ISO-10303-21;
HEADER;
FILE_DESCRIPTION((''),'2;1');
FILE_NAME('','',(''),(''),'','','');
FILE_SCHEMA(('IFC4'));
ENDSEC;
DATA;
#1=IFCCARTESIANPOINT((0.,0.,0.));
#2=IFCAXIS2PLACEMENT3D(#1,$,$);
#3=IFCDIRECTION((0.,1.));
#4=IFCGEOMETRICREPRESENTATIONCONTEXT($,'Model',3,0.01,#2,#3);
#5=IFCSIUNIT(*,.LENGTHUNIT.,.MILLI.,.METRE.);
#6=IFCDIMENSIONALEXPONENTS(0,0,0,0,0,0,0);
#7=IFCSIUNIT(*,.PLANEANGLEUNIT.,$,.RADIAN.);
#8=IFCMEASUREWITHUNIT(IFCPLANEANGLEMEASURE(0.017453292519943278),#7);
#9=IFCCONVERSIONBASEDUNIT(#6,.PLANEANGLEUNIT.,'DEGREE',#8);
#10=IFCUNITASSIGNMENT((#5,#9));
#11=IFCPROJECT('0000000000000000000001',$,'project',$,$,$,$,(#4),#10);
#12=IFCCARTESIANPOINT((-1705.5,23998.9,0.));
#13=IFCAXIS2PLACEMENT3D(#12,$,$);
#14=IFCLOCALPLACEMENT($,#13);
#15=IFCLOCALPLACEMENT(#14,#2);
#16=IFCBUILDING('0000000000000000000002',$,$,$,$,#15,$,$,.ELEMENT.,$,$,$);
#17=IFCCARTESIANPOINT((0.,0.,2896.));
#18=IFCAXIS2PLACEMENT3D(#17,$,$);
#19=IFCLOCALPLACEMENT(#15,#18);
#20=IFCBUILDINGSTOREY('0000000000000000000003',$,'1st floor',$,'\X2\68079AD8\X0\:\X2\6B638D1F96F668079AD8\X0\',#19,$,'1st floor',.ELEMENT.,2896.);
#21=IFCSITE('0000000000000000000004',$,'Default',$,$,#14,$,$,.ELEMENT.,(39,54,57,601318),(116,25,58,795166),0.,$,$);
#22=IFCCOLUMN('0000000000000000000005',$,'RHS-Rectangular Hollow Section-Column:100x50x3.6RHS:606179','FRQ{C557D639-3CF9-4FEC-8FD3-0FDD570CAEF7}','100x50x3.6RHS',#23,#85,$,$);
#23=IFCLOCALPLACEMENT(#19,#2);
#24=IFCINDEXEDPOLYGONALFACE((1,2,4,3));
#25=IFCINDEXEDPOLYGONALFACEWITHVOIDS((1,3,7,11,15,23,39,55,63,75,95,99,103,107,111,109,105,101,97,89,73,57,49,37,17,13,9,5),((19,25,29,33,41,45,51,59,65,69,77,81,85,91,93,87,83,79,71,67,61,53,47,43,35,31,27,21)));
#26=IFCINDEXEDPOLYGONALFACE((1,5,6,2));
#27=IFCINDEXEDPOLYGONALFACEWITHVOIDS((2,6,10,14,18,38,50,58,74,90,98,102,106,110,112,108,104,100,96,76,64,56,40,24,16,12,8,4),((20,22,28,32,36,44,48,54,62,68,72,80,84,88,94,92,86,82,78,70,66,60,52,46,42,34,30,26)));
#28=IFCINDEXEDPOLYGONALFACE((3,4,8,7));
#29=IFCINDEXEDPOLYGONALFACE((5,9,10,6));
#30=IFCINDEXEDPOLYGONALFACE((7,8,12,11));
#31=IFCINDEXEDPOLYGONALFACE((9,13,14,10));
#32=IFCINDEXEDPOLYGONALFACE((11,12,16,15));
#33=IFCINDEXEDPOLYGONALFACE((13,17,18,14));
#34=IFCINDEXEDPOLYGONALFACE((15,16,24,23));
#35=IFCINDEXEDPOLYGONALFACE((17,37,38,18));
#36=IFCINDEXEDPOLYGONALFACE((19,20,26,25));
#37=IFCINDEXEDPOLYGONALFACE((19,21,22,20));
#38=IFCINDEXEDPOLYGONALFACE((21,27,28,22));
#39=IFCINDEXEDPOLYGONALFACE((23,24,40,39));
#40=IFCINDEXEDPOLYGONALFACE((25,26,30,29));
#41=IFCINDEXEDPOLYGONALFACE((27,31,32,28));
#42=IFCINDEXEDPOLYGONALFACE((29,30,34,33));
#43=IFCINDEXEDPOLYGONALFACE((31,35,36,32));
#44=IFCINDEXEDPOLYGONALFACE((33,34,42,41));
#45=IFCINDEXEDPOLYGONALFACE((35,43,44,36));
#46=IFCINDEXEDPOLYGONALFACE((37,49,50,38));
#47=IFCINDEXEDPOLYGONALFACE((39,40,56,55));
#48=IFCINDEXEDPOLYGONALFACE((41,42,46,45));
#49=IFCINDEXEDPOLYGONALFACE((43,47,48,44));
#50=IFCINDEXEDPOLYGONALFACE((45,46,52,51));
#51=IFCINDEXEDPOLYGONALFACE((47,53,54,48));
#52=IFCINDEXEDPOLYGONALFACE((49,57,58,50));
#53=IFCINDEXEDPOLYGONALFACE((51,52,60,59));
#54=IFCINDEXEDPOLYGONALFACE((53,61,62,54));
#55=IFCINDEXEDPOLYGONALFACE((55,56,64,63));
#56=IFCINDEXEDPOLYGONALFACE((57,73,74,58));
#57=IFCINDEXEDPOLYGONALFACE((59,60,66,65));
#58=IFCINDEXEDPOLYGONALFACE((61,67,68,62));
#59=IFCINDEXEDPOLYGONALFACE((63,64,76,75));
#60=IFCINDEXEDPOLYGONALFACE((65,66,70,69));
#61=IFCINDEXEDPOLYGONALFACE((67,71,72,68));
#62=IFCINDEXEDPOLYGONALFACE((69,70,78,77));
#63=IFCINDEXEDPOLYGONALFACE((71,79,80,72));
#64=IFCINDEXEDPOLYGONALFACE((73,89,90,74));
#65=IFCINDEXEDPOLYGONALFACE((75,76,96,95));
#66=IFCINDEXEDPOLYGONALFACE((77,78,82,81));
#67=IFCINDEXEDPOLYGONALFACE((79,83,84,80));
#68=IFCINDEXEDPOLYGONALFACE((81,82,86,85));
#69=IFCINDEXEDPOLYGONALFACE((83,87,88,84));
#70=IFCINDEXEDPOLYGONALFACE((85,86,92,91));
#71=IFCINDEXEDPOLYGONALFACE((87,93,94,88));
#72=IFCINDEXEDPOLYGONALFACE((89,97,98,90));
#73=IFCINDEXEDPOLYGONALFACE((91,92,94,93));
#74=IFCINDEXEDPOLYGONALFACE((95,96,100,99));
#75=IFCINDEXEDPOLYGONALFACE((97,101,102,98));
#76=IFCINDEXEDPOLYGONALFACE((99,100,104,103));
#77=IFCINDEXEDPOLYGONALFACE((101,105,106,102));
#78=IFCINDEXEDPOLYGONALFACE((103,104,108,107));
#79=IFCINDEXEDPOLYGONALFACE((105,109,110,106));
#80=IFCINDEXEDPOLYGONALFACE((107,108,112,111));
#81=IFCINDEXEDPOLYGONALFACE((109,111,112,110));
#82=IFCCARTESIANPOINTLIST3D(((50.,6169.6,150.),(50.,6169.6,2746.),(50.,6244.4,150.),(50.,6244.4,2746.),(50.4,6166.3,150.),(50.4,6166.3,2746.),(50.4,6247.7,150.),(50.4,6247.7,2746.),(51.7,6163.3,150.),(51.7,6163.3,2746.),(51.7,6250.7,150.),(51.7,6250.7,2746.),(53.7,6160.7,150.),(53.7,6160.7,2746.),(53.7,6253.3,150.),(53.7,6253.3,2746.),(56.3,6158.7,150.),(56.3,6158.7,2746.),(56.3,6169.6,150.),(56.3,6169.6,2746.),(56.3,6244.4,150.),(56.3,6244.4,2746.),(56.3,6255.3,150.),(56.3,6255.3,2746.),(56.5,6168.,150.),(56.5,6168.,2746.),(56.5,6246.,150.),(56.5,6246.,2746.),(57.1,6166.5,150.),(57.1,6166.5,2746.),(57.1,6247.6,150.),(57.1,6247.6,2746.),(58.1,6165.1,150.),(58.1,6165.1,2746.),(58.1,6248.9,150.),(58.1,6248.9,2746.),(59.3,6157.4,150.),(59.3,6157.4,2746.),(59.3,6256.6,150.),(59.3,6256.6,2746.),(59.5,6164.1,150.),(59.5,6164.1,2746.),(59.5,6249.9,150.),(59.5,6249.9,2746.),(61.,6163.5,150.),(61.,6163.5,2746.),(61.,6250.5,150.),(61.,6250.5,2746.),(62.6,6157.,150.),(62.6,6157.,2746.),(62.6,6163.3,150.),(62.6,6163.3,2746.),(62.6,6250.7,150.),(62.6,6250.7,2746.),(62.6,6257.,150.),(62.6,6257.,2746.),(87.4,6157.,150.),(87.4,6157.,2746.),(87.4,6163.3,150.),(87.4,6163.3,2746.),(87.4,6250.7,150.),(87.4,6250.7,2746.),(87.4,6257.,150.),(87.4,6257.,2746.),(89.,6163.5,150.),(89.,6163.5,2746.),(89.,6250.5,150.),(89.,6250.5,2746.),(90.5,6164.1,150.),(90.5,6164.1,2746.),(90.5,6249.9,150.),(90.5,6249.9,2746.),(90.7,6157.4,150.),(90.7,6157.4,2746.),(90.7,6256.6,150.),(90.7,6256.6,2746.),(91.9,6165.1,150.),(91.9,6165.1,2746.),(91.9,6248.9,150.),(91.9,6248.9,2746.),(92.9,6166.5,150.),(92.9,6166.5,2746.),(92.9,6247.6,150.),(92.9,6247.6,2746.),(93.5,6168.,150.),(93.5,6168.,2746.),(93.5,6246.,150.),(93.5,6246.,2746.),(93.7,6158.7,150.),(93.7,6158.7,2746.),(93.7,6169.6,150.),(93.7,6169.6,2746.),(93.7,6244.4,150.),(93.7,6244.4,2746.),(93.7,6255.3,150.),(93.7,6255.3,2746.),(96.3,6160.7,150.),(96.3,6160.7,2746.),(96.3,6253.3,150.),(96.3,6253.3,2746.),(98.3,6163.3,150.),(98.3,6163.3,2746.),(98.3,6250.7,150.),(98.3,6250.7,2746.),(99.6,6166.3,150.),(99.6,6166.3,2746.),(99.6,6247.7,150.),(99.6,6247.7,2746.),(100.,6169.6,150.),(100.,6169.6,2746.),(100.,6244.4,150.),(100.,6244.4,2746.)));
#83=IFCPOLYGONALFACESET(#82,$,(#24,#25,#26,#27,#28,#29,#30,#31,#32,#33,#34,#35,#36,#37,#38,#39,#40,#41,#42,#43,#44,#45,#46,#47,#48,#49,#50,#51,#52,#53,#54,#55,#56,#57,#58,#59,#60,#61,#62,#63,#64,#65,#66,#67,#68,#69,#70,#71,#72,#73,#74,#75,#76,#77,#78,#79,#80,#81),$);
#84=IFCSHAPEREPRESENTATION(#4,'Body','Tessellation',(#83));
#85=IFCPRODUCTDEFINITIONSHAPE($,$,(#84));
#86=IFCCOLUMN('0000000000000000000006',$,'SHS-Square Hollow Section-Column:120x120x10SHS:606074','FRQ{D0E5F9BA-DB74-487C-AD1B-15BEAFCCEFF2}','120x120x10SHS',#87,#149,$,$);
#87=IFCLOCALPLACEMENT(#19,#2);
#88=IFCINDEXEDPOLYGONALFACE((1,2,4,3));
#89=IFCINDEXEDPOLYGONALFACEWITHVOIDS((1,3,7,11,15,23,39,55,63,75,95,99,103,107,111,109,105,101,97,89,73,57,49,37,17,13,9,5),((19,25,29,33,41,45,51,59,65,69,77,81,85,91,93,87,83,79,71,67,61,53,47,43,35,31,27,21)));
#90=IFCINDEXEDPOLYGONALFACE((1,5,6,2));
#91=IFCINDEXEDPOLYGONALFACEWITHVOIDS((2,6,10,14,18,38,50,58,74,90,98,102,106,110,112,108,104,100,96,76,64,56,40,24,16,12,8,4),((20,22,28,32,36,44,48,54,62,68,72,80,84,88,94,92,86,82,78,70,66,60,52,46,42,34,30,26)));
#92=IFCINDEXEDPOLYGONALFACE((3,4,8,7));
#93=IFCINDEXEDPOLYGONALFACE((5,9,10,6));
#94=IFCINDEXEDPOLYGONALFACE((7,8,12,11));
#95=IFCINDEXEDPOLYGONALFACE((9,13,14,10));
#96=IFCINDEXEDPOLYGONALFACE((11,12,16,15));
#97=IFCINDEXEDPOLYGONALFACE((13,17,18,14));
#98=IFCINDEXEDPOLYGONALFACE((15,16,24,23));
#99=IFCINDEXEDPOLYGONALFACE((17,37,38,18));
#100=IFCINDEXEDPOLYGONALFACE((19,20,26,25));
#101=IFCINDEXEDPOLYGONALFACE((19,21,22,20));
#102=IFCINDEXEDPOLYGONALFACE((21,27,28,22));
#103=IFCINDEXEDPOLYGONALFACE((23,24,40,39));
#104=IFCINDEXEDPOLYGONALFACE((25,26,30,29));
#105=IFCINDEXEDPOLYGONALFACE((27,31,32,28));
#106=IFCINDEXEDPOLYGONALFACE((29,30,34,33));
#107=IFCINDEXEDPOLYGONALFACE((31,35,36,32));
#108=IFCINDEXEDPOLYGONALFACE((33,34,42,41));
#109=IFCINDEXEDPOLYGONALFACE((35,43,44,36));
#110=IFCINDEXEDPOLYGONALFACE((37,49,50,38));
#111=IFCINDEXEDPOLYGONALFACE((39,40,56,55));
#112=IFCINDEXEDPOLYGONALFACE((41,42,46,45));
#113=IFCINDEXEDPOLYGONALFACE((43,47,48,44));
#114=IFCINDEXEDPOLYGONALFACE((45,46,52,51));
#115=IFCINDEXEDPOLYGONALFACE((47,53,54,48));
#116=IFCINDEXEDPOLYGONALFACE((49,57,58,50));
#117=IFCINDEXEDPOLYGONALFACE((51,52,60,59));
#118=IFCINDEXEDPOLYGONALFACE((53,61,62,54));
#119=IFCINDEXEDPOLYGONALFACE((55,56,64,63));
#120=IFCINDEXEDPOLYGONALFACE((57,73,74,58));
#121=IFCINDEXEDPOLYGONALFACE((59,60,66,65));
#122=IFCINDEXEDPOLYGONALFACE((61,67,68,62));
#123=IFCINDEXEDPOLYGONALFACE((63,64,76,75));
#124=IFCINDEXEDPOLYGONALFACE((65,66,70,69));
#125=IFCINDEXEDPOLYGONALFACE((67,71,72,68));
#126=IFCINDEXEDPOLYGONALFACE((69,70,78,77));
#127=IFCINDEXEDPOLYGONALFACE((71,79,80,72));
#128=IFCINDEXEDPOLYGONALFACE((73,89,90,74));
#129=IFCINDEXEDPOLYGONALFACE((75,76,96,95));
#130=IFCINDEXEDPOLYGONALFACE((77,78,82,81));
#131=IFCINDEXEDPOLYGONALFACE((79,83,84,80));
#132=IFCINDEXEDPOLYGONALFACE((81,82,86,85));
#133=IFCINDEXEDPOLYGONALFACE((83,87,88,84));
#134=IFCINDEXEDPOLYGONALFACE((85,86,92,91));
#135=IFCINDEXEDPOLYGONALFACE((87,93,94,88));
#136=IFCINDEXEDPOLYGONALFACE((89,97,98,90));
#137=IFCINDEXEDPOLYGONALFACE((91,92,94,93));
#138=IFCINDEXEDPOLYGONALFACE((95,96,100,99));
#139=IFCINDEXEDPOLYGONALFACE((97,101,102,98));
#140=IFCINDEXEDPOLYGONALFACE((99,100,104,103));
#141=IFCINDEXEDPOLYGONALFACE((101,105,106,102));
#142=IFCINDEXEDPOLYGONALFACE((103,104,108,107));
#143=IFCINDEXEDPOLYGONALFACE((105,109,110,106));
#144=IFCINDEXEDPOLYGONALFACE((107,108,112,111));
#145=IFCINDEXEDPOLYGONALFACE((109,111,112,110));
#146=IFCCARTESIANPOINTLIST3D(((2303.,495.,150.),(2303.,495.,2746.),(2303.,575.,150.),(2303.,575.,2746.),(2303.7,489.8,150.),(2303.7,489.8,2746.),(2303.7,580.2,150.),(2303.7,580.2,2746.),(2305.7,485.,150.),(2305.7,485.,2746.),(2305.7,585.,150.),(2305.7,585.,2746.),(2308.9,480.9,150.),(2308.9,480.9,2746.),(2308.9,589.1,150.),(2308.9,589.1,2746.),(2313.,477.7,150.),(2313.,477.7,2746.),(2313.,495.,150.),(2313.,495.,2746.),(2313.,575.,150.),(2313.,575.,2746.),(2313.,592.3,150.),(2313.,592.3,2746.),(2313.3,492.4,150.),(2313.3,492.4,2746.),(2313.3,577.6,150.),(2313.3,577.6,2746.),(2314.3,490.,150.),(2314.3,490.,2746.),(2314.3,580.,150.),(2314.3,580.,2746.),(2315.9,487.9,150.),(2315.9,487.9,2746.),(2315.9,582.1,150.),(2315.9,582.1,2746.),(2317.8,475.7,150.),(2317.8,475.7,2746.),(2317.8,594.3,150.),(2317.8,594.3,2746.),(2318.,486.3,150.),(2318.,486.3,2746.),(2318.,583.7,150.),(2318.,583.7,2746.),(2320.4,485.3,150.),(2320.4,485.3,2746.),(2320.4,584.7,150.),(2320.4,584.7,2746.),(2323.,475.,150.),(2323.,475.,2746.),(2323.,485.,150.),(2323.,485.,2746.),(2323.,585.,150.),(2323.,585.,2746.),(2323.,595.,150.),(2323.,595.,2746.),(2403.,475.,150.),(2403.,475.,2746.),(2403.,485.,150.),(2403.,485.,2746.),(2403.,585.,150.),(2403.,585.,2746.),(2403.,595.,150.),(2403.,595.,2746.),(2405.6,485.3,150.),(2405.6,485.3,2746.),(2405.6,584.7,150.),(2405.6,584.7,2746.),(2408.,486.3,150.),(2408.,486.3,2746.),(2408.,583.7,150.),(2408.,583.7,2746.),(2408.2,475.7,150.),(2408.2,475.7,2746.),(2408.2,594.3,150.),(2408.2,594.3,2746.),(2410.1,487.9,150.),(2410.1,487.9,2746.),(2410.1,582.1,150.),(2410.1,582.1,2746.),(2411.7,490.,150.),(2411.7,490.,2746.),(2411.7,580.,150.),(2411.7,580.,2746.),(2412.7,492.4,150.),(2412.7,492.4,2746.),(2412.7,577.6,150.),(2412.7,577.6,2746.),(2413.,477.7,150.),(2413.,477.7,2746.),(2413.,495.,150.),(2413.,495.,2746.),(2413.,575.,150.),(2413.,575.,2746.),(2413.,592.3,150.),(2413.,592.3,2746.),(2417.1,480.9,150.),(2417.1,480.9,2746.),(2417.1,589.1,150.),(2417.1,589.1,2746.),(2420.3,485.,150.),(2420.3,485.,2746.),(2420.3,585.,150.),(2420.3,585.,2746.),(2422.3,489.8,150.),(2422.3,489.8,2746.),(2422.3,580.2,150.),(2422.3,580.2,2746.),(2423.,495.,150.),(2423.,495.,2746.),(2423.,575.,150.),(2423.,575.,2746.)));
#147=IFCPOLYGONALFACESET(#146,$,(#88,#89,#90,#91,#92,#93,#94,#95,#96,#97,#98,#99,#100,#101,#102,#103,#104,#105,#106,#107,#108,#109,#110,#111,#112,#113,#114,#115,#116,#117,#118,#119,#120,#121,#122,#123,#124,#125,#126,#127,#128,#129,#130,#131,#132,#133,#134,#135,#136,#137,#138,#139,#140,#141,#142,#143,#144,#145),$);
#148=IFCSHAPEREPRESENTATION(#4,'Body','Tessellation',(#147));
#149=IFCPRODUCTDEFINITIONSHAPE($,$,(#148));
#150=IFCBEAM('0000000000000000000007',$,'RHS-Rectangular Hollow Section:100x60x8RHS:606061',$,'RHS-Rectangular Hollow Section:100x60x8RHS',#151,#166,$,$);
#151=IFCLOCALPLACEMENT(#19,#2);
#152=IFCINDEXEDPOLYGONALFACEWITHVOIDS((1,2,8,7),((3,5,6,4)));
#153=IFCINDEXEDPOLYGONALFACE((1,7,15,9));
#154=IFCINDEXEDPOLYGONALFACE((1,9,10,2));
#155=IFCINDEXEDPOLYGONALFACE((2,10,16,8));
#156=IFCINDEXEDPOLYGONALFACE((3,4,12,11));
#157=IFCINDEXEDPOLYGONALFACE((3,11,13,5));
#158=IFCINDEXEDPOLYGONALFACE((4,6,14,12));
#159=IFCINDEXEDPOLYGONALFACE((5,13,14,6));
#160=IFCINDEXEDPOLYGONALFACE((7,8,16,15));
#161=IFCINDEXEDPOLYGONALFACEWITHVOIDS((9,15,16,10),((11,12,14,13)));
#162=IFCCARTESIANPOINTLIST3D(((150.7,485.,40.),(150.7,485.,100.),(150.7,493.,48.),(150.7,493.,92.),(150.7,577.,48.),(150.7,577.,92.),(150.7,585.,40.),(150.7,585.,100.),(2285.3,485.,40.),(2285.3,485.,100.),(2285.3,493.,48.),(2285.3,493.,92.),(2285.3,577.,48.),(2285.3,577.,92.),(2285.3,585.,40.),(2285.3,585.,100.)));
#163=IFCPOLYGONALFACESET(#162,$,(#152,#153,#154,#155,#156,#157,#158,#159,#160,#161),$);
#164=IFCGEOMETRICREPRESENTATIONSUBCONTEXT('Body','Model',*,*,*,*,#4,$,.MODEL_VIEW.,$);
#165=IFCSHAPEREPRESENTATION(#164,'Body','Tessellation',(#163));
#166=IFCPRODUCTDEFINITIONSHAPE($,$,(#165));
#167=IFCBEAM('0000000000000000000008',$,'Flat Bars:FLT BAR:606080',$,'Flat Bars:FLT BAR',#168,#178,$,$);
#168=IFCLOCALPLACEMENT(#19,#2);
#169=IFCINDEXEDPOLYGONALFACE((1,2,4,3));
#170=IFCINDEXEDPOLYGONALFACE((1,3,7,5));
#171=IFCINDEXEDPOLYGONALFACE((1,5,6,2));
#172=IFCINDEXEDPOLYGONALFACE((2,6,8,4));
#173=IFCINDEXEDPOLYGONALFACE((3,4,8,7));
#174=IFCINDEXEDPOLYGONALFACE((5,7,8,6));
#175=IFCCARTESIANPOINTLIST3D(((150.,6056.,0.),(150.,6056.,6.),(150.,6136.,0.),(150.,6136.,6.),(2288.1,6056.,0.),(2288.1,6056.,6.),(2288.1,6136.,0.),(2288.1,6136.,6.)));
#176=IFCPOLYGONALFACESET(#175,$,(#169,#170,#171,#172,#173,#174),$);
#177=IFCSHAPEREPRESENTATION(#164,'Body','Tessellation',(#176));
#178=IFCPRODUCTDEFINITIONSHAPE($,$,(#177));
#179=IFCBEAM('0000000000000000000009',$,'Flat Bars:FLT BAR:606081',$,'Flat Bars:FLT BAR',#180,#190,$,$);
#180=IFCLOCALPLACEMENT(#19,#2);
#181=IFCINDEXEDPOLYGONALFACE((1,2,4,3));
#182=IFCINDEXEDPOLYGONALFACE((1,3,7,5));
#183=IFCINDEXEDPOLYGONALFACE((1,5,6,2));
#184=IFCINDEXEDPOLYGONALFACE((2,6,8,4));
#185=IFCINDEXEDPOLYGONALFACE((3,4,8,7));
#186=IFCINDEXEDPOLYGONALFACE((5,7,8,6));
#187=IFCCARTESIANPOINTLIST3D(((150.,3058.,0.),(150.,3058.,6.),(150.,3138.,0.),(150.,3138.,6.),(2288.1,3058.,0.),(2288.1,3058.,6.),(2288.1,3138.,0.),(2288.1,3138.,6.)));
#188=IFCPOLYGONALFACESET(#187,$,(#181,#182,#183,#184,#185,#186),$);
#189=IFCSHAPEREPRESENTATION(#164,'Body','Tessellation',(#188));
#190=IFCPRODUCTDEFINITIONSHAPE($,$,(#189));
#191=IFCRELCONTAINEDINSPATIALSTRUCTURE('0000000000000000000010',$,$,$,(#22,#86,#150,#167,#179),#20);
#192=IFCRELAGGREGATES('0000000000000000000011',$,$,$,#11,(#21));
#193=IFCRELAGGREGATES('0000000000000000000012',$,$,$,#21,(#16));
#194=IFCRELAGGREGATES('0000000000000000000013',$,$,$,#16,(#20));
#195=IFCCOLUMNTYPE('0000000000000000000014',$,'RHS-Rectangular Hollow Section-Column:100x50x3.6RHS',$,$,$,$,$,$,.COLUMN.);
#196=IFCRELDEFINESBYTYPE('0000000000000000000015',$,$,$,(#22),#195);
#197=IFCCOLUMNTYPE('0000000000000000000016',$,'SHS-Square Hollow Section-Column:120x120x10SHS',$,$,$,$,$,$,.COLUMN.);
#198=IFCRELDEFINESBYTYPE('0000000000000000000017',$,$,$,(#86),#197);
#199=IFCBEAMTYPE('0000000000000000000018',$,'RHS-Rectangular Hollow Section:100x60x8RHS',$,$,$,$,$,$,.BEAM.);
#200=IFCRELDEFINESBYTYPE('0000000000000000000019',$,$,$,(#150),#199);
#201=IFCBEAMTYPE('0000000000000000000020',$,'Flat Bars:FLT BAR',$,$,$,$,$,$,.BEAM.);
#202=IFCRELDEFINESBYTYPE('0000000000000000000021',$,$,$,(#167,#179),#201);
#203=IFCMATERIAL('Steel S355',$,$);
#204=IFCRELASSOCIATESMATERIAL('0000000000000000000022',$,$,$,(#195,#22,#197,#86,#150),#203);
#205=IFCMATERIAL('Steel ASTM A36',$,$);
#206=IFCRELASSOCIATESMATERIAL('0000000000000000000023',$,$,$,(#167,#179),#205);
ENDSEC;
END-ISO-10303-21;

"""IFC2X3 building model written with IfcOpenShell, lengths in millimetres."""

from ifc_helpers import new_model, entity, si_unit, converted_unit, direction, frame, frame_2d, origin, origin_2d, origin_2d_with_axis, place, context, subcontext, project, spatial, rectangle, hollow_rectangle, extrude, boolean, clip, halfspace, material, type_object, element, save


model = new_model("IFC2X3")

# Units and contexts
model_context = context("Model", 3, precision=0.01, world=origin(), true_north=direction((0.0, 1.0)))
body_context = subcontext(model_context, "Body", "Model", "MODEL_VIEW")
ifc_project = project(units=[si_unit("LENGTHUNIT", "METRE", prefix="MILLI"), converted_unit("PLANEANGLEUNIT", "DEGREE", entity("IfcPlaneAngleMeasure", 0.017453292519943278), si_unit("PLANEANGLEUNIT", "RADIAN"), dimensions=[0, 0, 0, 0, 0, 0, 0])], contexts=[model_context])

# Site, building, storey
site_placement = place(None, frame((-1705.5, 23998.9, 0.0)))
site = spatial("IfcSite", under=ifc_project, at=site_placement, Name="Default", CompositionType="ELEMENT", RefLatitude=(39, 54, 57, 601318), RefLongitude=(116, 25, 58, 795166), RefElevation=0.0)
building_placement = place(site_placement, origin())
building = spatial("IfcBuilding", under=site, at=building_placement, CompositionType="ELEMENT")
storey_placement = place(building_placement, frame((0.0, 0.0, 2896.0)))
storey = spatial("IfcBuildingStorey", under=building, at=storey_placement, Name="1st floor", ObjectType="标高:正负零标高", LongName="1st floor", CompositionType="ELEMENT", Elevation=2896.0)

# Shared definitions
ifc_material_1 = material(Name="Steel S355")

# Columns
column_type_1 = type_object("IfcColumnType", Name="RHS-Rectangular Hollow Section-Column:100x50x3.6RHS", PredefinedType="COLUMN", material=ifc_material_1)
column_1_placement = place(storey_placement, frame((75.0, 6207.0, 2746.0), z_axis=(0.0, 0.0, 1.0), x_axis=(-1.0, 0.0, 0.0)))
element("IfcColumn", 1, at=column_1_placement, inside=storey, type_object=column_type_1, material=ifc_material_1, Name="RHS-Rectangular Hollow Section-Column:100x50x3.6RHS:606179", Description="FRQ{C557D639-3CF9-4FEC-8FD3-0FDD570CAEF7}", ObjectType="100x50x3.6RHS", context=model_context, shape_type="Clipping", body=[
    clip(extrude(hollow_rectangle(XDim=50.0, YDim=100.0, WallThickness=6.3, InnerFilletRadius=6.3, OuterFilletRadius=12.6, at=origin_2d()), origin(), (0.0, 0.0, -1.0), 2651.9), halfspace(frame((75.0, 6207.0, -2596.0), z_axis=(0.0, 0.0, 1.0), x_axis=(-1.0, 0.0, 0.0)), True)),
])
column_type_2 = type_object("IfcColumnType", Name="SHS-Square Hollow Section-Column:120x120x10SHS", PredefinedType="COLUMN", material=ifc_material_1)
column_2_placement = place(storey_placement, frame((2363.0, 535.0, 2746.0), z_axis=(0.0, 0.0, 1.0), x_axis=(0.0, -1.0, 0.0)))
element("IfcColumn", 2, at=column_2_placement, inside=storey, type_object=column_type_2, material=ifc_material_1, Name="SHS-Square Hollow Section-Column:120x120x10SHS:606074", Description="FRQ{D0E5F9BA-DB74-487C-AD1B-15BEAFCCEFF2}", ObjectType="120x120x10SHS", context=model_context, shape_type="Clipping", body=[
    clip(extrude(hollow_rectangle(XDim=120.0, YDim=120.0, WallThickness=10.0, InnerFilletRadius=10.0, OuterFilletRadius=20.0, at=origin_2d()), origin(), (0.0, 0.0, -1.0), 2680.9), halfspace(frame((535.0, -2363.0, -2596.0), z_axis=(0.0, 0.0, 1.0), x_axis=(0.0, 1.0, 0.0)), True)),
])

# Beams
beam_type_1 = type_object("IfcBeamType", Name="RHS-Rectangular Hollow Section:100x60x8RHS", PredefinedType="BEAM")
beam_1_placement = place(storey_placement, frame((150.7, 585.0, 70.0)))
element("IfcBeam", 3, at=beam_1_placement, inside=storey, type_object=beam_type_1, material=ifc_material_1, Name="RHS-Rectangular Hollow Section:100x60x8RHS:606061", ObjectType="RHS-Rectangular Hollow Section:100x60x8RHS", context=body_context, shape_type="SweptSolid", body=[
    boolean("DIFFERENCE", extrude(rectangle(XDim=60.0, YDim=100.0, at=frame_2d((0.0, 0.0), x_axis=(1.0, 0.0))), frame((0.0, -50.0, 0.0), z_axis=(1.0, 0.0, 0.0), x_axis=(0.0, 0.0, -1.0)), (0.0, 0.0, 1.0), 2134.6), extrude(rectangle(XDim=44.0, YDim=84.0, at=frame_2d((0.0, 0.0), x_axis=(0.0, 1.0))), frame((2134.6, -50.0, 0.0), z_axis=(-1.0, 0.0, 0.0), x_axis=(0.0, 1.0, 0.0)), (0.0, 0.0, 1.0), 2134.6)),
])
ifc_material_2 = material(Name="Steel ASTM A36")
beam_type_2 = type_object("IfcBeamType", Name="Flat Bars:FLT BAR", PredefinedType="BEAM")
for number, where, name in (
    (4, (150.0, 6096.0, 6.0), "Flat Bars:FLT BAR:606080"),
    (5, (150.0, 3098.0, 6.0), "Flat Bars:FLT BAR:606081"),
):
    element("IfcBeam", number, at=place(storey_placement, frame(where)), inside=storey, type_object=beam_type_2, material=ifc_material_2, Name=name, ObjectType="Flat Bars:FLT BAR", context=body_context, shape_type="SweptSolid", body=[
        extrude(rectangle(XDim=6.0, YDim=80.0, at=origin_2d_with_axis()), frame((0.0, 0.0, -3.0), z_axis=(1.0, 0.0, 0.0), x_axis=(0.0, 0.0, -1.0)), (0.0, 0.0, 1.0), 2138.1),
    ])

save(model, "model.ifc")
